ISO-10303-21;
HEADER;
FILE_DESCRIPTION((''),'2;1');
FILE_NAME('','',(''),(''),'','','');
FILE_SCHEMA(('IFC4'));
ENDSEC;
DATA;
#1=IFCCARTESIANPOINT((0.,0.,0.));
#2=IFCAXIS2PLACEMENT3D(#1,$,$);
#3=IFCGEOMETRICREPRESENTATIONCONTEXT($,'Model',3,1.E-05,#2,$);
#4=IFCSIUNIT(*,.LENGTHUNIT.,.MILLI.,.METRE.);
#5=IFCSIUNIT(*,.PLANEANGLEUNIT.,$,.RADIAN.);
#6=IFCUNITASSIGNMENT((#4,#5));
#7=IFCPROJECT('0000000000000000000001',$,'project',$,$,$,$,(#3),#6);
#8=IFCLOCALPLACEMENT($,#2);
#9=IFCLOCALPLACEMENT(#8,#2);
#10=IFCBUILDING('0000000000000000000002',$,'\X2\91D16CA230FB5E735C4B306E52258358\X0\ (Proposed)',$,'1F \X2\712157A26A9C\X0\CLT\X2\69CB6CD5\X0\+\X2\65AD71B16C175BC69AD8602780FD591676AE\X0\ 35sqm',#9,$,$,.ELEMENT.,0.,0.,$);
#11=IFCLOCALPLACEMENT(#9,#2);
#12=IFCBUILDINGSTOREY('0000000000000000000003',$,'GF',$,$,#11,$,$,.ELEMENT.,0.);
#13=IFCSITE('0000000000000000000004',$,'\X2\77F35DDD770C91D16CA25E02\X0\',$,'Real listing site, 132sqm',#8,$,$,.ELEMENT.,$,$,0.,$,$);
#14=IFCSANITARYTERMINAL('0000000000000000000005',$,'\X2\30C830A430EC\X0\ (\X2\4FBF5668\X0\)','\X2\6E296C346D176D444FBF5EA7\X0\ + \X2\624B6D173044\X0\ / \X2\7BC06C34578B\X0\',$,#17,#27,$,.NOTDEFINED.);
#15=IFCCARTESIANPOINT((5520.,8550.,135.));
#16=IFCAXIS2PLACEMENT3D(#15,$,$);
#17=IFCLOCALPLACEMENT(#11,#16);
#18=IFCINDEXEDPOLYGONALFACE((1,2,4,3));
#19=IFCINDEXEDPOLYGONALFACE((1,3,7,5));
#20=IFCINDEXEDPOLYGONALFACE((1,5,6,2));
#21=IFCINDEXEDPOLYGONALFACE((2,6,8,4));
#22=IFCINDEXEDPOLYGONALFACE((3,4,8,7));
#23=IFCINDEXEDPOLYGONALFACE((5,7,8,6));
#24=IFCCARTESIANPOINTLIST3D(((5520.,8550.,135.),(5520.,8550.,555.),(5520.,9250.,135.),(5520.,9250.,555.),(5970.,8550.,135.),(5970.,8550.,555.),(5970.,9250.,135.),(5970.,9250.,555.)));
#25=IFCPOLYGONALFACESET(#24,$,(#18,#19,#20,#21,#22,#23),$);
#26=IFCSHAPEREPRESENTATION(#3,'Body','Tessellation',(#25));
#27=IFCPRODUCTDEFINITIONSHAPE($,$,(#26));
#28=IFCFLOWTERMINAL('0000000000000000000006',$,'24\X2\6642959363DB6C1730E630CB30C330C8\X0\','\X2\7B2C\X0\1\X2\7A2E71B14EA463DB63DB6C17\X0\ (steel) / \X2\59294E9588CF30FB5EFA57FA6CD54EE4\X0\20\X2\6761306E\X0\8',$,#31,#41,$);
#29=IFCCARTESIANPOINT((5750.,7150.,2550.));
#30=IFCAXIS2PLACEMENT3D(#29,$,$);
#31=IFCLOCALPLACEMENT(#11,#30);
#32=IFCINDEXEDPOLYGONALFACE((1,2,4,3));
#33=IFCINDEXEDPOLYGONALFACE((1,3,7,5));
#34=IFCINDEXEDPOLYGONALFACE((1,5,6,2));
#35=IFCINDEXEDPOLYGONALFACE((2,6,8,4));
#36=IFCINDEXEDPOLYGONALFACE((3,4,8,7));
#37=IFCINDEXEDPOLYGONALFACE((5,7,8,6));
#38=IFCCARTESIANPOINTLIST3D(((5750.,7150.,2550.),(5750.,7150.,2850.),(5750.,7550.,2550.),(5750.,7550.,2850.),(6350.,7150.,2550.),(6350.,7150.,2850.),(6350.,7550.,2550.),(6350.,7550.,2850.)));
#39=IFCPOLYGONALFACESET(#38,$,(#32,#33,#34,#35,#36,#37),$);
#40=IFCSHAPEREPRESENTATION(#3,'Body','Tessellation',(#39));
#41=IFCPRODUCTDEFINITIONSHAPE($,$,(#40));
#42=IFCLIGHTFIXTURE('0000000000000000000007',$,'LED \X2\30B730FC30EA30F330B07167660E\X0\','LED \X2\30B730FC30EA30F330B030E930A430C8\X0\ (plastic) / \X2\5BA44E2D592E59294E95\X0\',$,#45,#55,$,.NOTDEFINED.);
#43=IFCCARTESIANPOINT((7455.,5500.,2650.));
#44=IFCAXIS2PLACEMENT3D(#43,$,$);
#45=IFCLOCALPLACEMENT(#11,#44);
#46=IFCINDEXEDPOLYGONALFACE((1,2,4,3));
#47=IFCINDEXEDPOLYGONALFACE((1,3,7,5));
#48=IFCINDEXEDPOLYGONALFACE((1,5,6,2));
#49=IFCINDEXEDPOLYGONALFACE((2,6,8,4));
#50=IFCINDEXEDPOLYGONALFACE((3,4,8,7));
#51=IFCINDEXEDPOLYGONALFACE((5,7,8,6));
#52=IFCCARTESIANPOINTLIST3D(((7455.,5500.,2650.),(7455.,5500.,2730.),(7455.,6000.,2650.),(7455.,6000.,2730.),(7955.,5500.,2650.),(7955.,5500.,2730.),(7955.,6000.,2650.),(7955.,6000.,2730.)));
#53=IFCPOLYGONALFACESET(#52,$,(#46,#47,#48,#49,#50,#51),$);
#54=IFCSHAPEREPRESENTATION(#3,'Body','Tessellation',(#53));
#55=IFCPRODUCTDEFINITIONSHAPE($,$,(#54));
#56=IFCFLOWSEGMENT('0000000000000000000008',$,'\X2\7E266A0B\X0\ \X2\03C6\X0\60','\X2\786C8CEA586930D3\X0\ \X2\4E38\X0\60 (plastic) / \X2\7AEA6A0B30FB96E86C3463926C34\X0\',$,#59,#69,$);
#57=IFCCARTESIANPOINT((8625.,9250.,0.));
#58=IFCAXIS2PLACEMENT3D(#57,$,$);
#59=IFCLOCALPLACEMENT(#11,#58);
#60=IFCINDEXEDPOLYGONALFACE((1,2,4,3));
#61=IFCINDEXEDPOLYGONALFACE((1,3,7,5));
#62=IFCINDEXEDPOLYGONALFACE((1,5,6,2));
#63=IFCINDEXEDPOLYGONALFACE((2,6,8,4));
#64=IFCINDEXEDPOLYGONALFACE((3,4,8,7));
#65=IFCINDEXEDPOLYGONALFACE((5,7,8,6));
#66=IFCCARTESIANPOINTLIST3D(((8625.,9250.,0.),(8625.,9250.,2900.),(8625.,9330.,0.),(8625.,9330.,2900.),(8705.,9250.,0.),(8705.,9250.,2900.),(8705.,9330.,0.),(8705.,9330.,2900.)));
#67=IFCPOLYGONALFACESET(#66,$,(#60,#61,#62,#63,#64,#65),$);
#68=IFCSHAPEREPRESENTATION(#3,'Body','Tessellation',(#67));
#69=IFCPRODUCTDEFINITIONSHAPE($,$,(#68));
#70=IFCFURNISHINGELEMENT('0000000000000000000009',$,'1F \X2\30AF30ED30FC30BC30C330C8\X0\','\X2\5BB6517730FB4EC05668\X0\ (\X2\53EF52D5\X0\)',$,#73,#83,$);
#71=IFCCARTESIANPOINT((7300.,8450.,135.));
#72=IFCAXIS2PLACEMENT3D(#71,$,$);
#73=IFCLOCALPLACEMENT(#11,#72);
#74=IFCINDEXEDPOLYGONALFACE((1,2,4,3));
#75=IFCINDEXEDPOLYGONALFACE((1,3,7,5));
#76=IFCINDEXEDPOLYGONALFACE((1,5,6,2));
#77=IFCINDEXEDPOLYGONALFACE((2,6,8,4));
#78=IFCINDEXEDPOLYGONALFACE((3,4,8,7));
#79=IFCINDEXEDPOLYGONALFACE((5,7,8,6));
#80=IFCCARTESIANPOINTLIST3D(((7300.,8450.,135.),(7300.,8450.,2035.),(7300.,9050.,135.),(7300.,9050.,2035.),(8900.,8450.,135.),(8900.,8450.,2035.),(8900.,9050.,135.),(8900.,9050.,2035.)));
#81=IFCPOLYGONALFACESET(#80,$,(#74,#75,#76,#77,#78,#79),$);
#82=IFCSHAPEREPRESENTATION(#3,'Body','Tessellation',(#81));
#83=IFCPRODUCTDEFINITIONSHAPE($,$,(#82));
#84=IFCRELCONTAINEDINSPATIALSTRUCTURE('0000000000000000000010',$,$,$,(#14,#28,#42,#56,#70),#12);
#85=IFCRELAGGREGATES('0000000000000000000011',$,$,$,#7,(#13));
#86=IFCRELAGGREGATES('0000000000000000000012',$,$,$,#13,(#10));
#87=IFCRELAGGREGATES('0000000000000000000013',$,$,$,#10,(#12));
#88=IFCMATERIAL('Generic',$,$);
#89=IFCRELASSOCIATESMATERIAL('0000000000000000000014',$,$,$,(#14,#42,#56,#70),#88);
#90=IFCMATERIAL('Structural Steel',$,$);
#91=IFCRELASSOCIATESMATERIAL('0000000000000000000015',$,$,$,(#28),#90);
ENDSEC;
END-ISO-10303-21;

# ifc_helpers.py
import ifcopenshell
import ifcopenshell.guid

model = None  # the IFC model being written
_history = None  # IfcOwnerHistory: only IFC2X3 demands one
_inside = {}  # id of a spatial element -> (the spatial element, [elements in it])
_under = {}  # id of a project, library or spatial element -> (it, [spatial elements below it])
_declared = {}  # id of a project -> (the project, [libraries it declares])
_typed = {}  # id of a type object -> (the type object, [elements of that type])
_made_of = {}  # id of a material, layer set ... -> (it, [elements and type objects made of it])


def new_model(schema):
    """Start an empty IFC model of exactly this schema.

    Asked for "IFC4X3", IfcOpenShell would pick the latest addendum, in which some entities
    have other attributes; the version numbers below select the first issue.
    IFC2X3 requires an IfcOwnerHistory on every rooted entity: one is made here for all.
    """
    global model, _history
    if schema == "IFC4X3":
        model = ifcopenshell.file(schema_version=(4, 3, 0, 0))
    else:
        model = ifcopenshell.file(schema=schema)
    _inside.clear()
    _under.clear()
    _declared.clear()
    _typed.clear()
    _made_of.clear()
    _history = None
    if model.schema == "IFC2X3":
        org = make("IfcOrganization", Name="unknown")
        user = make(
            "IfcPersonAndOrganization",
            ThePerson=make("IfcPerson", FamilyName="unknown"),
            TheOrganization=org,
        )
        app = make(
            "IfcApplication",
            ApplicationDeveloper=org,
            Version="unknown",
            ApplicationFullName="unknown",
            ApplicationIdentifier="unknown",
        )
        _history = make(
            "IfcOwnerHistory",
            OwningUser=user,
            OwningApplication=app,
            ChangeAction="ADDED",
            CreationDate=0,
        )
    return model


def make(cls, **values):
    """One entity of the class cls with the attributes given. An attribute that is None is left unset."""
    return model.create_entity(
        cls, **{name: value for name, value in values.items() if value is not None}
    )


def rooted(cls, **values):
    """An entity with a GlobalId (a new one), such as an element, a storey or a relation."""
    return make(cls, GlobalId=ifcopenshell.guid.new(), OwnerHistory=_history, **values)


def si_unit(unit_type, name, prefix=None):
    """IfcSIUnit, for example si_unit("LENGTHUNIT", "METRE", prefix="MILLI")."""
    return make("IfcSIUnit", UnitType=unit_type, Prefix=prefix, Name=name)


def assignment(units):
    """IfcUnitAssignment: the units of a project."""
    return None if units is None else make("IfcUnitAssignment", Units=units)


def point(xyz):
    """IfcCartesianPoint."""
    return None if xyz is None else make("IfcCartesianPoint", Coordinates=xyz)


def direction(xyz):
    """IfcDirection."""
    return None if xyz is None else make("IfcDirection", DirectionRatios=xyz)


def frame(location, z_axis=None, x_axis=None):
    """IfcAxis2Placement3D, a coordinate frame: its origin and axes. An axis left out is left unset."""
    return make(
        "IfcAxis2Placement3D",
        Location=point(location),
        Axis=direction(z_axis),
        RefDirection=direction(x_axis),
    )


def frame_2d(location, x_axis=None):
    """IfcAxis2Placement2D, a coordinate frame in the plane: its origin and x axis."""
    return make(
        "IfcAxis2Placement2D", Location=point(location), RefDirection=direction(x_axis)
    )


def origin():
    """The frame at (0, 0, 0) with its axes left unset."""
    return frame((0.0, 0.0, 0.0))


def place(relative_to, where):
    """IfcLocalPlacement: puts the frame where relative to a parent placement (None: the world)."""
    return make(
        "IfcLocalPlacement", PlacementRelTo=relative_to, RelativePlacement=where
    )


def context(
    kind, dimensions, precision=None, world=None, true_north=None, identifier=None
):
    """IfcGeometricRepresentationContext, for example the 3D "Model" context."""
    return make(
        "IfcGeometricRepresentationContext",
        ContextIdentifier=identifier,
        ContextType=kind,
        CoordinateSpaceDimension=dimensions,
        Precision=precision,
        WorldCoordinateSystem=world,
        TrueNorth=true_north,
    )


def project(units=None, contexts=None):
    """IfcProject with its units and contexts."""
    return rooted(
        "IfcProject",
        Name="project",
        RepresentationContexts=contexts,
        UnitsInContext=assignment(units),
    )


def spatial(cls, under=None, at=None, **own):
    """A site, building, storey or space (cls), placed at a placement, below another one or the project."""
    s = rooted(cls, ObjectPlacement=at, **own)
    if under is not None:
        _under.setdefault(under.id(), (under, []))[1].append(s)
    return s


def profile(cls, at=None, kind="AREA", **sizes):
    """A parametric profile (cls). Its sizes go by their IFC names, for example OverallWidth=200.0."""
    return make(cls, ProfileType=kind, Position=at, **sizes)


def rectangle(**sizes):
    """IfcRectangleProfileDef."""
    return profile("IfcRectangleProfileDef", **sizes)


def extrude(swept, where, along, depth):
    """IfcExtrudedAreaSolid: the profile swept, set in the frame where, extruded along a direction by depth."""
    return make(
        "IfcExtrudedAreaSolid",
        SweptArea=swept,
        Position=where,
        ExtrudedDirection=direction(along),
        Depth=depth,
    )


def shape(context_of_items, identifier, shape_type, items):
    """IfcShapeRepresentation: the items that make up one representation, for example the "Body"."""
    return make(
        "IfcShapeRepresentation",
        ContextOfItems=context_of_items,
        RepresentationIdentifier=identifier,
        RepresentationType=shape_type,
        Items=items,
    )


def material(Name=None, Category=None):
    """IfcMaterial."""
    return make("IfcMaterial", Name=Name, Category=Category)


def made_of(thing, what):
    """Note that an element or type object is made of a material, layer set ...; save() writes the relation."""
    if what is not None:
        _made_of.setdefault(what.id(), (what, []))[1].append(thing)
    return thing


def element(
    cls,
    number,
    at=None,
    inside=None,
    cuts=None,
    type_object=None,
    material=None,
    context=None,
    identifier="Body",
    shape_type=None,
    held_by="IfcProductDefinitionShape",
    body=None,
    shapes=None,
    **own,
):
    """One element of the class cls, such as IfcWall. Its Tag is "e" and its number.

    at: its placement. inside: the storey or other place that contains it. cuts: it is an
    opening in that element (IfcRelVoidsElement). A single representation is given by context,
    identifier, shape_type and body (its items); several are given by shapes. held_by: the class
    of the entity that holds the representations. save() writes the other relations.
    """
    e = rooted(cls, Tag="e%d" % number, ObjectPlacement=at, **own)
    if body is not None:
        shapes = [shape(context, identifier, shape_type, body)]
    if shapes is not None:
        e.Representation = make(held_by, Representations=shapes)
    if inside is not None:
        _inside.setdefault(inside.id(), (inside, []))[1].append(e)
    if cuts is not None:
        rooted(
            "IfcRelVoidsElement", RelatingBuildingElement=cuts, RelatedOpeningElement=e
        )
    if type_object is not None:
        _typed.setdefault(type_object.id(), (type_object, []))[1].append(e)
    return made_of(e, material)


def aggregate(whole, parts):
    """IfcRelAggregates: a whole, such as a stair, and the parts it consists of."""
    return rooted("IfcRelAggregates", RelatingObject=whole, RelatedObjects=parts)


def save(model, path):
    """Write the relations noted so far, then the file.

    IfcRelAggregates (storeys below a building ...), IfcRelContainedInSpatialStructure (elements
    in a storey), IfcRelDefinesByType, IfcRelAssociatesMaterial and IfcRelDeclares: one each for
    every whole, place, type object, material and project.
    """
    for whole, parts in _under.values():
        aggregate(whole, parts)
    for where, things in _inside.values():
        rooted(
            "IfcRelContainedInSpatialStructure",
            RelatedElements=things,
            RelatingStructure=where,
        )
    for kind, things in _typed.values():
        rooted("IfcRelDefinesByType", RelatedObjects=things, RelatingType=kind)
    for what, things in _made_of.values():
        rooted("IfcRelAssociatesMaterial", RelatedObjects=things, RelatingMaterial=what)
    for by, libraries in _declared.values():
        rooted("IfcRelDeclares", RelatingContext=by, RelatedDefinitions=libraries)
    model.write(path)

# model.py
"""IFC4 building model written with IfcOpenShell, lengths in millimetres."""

from ifc_helpers import new_model, si_unit, frame, frame_2d, origin, place, context, project, spatial, rectangle, extrude, material, element, save


model = new_model("IFC4")

# Units and contexts
model_context = context("Model", 3, precision=1e-05, world=origin())
ifc_project = project(units=[si_unit("LENGTHUNIT", "METRE", prefix="MILLI"), si_unit("PLANEANGLEUNIT", "RADIAN")], contexts=[model_context])

# Site, building, storey
site_placement = place(None, origin())
site = spatial("IfcSite", under=ifc_project, at=site_placement, Name="石川県金沢市", ObjectType="Real listing site, 132sqm", CompositionType="ELEMENT", RefElevation=0.0)
building_placement = place(site_placement, origin())
building = spatial("IfcBuilding", under=site, at=building_placement, Name="金沢・平屋の別荘 (Proposed)", ObjectType="1F 無垢檜CLT構法+断熱気密高性能外皮 35sqm", CompositionType="ELEMENT", ElevationOfRefHeight=0.0, ElevationOfTerrain=0.0)
storey_placement = place(building_placement, origin())
storey = spatial("IfcBuildingStorey", under=building, at=storey_placement, Name="GF", CompositionType="ELEMENT", Elevation=0.0)

# Shared definitions
ifc_material_1 = material(Name="Generic")

# Sanitary terminal
sanitary_terminal_placement = place(storey_placement, frame((5520.0, 8550.0, 135.0)))
element("IfcSanitaryTerminal", 1, at=sanitary_terminal_placement, inside=storey, material=ifc_material_1, Name="トイレ (便器)", Description="温水洗浄便座 + 手洗い / 節水型", PredefinedType="NOTDEFINED", context=model_context, shape_type="SweptSolid", body=[
    extrude(rectangle(XDim=450.0, YDim=700.0, at=frame_2d((225.0, 350.0))), frame((5520.0, 8550.0, 135.0)), (0.0, 0.0, 1.0), 420.0),
])

# Flow terminal
ifc_material_2 = material(Name="Structural Steel")
flow_terminal_placement = place(storey_placement, frame((5750.0, 7150.0, 2550.0)))
element("IfcFlowTerminal", 2, at=flow_terminal_placement, inside=storey, material=ifc_material_2, Name="24時間換気ユニット", Description="第1種熱交換換気 (steel) / 天井裏・建基法令20条の8", context=model_context, shape_type="SweptSolid", body=[
    extrude(rectangle(XDim=600.0, YDim=400.0, at=frame_2d((300.0, 200.0))), frame((5750.0, 7150.0, 2550.0)), (0.0, 0.0, 1.0), 300.0),
])

# Light fixture
light_fixture_placement = place(storey_placement, frame((7455.0, 5500.0, 2650.0)))
element("IfcLightFixture", 3, at=light_fixture_placement, inside=storey, material=ifc_material_1, Name="LED シーリング照明", Description="LED シーリングライト (plastic) / 室中央天井", PredefinedType="NOTDEFINED", context=model_context, shape_type="SweptSolid", body=[
    extrude(rectangle(XDim=500.0, YDim=500.0, at=frame_2d((250.0, 250.0))), frame((7455.0, 5500.0, 2650.0)), (0.0, 0.0, 1.0), 80.0),
])

# Flow segment
flow_segment_placement = place(storey_placement, frame((8625.0, 9250.0, 0.0)))
element("IfcFlowSegment", 4, at=flow_segment_placement, inside=storey, material=ifc_material_1, Name="縦樋 φ60", Description="硬質塩ビ 丸60 (plastic) / 竪樋・雨水排水", context=model_context, shape_type="SweptSolid", body=[
    extrude(rectangle(XDim=80.0, YDim=80.0, at=frame_2d((40.0, 40.0))), frame((8625.0, 9250.0, 0.0)), (0.0, 0.0, 1.0), 2900.0),
])

# Furnishing element
furnishing_placement = place(storey_placement, frame((7300.0, 8450.0, 135.0)))
element("IfcFurnishingElement", 5, at=furnishing_placement, inside=storey, material=ifc_material_1, Name="1F クローゼット", Description="家具・什器 (可動)", context=model_context, shape_type="SweptSolid", body=[
    extrude(rectangle(XDim=1600.0, YDim=600.0, at=frame_2d((800.0, 300.0))), frame((7300.0, 8450.0, 135.0)), (0.0, 0.0, 1.0), 1900.0),
])

save(model, "model.ifc")
